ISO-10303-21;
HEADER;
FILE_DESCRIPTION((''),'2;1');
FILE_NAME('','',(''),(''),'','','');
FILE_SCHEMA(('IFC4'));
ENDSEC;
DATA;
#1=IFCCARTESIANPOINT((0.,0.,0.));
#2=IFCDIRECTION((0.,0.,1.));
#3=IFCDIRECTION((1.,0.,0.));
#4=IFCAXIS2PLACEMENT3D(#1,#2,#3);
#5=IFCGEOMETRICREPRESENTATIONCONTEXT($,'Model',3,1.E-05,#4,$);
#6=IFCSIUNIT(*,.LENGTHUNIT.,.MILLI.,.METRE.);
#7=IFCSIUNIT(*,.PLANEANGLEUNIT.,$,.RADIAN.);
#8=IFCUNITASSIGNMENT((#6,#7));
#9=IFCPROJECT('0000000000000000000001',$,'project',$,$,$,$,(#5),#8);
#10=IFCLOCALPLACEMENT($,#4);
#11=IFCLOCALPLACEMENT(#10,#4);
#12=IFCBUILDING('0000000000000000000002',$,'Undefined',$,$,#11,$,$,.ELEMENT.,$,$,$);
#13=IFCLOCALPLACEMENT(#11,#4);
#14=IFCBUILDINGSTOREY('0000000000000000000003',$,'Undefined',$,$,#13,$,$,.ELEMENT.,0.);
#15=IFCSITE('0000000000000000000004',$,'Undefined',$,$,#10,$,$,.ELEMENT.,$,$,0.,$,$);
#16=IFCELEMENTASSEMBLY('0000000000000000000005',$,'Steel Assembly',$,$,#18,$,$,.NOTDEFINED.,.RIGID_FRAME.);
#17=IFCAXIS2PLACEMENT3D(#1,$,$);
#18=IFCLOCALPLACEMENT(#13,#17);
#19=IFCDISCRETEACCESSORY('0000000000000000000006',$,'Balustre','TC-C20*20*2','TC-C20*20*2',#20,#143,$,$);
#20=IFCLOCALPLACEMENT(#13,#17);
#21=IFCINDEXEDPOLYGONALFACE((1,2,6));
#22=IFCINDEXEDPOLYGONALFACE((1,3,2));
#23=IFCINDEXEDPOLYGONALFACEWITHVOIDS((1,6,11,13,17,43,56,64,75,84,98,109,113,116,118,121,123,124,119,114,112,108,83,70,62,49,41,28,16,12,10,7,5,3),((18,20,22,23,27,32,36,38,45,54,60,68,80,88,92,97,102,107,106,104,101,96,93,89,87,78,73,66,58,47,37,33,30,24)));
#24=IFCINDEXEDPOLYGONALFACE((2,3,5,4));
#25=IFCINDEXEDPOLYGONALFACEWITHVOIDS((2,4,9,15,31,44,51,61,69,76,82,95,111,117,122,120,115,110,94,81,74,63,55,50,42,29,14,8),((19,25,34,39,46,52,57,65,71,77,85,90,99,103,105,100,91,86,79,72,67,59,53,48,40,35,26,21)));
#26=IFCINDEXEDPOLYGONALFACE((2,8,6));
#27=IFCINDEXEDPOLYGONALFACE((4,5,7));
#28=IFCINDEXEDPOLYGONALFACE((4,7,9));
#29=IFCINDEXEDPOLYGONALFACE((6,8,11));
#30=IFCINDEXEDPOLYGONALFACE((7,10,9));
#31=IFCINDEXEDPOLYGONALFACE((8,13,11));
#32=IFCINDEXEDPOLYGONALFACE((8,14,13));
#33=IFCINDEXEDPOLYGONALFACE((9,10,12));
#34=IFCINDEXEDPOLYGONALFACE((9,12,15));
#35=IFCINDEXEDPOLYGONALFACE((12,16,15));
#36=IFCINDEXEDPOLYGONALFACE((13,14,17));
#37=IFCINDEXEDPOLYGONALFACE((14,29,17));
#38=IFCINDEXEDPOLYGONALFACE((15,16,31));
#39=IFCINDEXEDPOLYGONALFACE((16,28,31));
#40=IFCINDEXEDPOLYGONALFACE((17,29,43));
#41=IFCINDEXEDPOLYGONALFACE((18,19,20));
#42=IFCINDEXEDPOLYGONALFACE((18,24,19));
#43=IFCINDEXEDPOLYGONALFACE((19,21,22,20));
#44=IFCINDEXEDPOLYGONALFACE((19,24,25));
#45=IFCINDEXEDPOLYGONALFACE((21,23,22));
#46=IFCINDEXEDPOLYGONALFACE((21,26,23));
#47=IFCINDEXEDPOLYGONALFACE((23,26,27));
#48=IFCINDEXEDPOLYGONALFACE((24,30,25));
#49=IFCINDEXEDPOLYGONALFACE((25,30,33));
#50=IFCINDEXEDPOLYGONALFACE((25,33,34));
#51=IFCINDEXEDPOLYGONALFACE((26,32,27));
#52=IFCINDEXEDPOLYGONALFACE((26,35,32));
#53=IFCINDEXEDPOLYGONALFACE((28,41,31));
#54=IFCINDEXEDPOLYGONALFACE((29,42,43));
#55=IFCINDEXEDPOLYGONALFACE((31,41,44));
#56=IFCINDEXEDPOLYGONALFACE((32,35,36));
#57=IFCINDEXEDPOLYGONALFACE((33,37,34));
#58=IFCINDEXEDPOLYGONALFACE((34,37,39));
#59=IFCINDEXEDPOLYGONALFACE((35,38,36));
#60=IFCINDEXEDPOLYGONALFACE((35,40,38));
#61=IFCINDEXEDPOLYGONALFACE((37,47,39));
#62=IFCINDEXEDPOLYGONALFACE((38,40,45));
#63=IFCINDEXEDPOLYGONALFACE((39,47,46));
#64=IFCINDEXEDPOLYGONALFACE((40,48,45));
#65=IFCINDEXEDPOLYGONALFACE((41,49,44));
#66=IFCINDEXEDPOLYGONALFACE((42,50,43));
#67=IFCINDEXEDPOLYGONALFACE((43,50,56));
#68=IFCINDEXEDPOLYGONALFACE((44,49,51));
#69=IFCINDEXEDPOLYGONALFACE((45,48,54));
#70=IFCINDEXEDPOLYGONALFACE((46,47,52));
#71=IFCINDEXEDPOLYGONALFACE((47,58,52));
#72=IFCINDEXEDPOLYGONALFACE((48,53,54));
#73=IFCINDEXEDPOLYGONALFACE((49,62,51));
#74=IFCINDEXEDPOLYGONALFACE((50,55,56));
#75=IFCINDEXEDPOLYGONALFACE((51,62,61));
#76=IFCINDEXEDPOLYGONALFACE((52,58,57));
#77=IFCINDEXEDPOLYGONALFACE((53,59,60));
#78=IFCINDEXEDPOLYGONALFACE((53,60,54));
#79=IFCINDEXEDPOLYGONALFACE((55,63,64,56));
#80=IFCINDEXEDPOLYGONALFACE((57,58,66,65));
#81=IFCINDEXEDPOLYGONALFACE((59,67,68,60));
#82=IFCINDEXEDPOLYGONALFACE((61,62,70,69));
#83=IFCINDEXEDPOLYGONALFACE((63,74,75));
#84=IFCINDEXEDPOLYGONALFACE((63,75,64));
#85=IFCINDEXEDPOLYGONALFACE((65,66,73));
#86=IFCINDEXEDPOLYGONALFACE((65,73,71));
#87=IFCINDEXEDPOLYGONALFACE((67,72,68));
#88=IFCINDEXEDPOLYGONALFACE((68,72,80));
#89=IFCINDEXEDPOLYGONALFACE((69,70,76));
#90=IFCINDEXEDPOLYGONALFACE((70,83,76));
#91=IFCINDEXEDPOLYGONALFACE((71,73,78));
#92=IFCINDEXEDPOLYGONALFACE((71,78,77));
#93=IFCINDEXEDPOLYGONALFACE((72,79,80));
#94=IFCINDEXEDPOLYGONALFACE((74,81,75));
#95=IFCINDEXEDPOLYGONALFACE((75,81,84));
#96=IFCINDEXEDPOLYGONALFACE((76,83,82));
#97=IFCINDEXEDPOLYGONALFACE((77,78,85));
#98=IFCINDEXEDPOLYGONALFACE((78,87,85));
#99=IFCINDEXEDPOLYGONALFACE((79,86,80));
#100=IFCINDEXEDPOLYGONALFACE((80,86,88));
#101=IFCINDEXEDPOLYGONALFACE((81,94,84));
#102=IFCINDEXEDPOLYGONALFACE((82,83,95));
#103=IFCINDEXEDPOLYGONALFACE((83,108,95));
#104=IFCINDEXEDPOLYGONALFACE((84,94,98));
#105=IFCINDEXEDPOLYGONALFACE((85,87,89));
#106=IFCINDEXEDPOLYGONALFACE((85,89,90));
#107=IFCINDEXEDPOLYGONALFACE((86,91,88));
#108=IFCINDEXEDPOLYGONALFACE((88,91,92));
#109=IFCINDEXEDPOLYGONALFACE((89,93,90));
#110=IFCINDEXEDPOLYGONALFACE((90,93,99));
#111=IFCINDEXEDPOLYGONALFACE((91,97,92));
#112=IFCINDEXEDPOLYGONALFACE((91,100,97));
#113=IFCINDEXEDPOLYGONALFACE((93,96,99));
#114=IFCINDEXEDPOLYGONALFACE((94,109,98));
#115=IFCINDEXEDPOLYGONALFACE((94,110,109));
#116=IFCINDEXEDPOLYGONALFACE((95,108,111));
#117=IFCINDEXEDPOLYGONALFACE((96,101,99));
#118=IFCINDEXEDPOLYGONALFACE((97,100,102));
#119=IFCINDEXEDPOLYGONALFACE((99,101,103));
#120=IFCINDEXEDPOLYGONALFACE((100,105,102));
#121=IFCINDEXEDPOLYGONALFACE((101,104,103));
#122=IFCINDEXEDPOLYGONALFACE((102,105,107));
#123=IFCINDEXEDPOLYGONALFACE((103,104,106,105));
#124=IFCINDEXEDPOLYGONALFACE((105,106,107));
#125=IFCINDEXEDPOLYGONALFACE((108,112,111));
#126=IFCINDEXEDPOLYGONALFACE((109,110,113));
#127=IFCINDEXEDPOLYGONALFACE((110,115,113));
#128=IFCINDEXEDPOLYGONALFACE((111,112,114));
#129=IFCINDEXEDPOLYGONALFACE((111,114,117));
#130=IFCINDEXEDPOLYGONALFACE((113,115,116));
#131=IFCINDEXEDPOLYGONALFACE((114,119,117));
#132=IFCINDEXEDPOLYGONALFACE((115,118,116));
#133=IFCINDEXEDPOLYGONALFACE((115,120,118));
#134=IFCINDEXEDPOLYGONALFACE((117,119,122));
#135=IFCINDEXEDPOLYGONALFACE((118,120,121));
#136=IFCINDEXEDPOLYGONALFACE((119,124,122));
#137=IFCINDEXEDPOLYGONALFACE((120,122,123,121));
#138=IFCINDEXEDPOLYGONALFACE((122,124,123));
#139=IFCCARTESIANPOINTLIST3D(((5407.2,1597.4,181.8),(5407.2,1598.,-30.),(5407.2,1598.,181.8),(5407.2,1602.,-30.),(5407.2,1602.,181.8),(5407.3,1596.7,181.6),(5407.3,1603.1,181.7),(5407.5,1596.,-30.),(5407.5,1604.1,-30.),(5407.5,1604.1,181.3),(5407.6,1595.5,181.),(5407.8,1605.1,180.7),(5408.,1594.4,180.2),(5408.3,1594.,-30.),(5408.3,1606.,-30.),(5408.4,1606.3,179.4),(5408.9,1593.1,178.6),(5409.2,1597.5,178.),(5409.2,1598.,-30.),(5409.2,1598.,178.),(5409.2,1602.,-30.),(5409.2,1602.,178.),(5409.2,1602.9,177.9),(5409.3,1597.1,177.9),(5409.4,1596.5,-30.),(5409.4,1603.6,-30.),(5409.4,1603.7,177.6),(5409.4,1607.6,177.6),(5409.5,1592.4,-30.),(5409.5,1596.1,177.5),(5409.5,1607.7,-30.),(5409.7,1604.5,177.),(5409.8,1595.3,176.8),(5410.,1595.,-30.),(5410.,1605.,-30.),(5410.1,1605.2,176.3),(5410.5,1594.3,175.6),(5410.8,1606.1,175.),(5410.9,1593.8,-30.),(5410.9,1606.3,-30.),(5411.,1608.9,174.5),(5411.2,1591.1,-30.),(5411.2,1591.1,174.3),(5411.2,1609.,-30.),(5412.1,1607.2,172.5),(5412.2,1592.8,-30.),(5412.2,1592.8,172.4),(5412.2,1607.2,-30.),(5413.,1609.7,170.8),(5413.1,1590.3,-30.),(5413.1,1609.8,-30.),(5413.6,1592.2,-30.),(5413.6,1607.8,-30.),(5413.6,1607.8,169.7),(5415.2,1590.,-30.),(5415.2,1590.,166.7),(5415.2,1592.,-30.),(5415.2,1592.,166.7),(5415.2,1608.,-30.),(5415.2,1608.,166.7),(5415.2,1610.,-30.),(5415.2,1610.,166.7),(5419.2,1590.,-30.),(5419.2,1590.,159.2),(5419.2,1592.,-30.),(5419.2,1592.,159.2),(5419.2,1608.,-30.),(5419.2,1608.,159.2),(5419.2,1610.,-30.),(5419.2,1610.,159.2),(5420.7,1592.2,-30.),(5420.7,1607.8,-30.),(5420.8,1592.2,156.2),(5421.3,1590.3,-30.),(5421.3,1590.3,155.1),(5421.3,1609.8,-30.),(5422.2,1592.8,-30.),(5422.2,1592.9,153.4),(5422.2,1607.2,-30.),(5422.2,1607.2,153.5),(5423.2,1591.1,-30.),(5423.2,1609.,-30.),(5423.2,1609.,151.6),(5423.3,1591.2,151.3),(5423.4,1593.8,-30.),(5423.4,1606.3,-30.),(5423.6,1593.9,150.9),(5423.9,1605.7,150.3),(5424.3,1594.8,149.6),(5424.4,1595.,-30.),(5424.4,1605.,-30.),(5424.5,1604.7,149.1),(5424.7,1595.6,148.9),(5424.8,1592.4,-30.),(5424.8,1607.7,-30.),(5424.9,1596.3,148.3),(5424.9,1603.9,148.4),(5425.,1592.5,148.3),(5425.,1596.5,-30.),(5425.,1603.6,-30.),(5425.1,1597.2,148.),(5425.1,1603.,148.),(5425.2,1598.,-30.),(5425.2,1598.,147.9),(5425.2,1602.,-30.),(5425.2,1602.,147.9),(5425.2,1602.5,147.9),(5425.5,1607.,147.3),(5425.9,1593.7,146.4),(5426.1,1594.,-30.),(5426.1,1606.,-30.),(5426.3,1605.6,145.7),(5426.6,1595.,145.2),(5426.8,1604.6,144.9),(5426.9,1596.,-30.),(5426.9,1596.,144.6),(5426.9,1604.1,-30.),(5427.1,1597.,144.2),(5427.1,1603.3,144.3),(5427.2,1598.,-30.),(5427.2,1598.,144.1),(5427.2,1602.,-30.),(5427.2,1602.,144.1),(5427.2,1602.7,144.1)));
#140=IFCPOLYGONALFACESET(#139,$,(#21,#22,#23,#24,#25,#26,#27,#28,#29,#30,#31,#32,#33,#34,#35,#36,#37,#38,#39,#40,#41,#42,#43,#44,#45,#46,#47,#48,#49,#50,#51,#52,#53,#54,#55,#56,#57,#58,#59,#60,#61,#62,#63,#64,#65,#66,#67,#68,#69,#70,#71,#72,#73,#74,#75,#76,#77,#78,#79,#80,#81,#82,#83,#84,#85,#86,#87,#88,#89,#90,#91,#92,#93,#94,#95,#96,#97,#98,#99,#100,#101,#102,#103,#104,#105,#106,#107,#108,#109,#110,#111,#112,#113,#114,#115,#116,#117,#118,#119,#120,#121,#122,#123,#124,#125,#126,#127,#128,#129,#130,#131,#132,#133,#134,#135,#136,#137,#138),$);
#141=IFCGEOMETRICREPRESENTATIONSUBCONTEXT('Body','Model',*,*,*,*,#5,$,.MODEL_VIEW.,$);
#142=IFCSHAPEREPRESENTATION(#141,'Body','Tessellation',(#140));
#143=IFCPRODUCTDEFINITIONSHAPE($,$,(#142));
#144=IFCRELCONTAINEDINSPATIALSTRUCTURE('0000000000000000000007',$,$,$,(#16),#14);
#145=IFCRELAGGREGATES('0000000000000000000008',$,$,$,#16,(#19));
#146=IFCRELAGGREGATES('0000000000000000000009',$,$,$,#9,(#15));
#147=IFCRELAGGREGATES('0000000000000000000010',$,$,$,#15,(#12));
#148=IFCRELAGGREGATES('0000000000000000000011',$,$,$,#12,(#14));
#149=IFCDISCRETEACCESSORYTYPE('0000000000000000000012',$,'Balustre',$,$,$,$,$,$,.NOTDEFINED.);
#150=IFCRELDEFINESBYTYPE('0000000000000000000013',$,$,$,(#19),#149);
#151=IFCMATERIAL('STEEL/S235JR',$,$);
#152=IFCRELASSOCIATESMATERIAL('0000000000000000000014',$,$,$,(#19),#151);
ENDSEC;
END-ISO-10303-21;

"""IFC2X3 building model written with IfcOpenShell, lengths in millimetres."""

from ifc_helpers import new_model, si_unit, frame, origin_with_axes, origin_2d_with_axis, place, context, subcontext, project, spatial, hollow_rectangle, extrude, clip, halfspace, material, type_object, element, aggregate, save


model = new_model("IFC2X3")

# Units and contexts
model_context = context("Model", 3, precision=1e-05, world=origin_with_axes())
body_context = subcontext(model_context, "Body", "Model", "MODEL_VIEW")
ifc_project = project(units=[si_unit("LENGTHUNIT", "METRE", prefix="MILLI"), si_unit("PLANEANGLEUNIT", "RADIAN")], contexts=[model_context])

# Site, building, storey
site_placement = place(None, origin_with_axes())
site = spatial("IfcSite", under=ifc_project, at=site_placement, Name="Undefined", CompositionType="ELEMENT", RefElevation=0.0)
building_placement = place(site_placement, origin_with_axes())
building = spatial("IfcBuilding", under=site, at=building_placement, Name="Undefined", CompositionType="ELEMENT")
storey_placement = place(building_placement, origin_with_axes())
storey = spatial("IfcBuildingStorey", under=building, at=storey_placement, Name="Undefined", CompositionType="ELEMENT", Elevation=0.0)

# Shared definitions
ifc_material = material(Name="STEEL/S235JR")

# Element assembly, discrete accessory
assembly_1_placement = place(storey_placement, origin_with_axes())
assembly_1 = element("IfcElementAssembly", 1, at=assembly_1_placement, inside=storey, Name="Steel Assembly", AssemblyPlace="NOTDEFINED", PredefinedType="RIGID_FRAME")
discrete_accessory_type_1 = type_object("IfcDiscreteAccessoryType", Name="Balustre")
discrete_accessory_1_placement = place(assembly_1_placement, frame((5417.2, 1600.0, -30.0), z_axis=(0.0, 0.0, 1.0), x_axis=(1.0, 0.0, 0.0)))
discrete_accessory_1 = element("IfcDiscreteAccessory", 2, at=discrete_accessory_1_placement, type_object=discrete_accessory_type_1, material=ifc_material, Name="Balustre", Description="TC-C20*20*2", ObjectType="TC-C20*20*2", context=body_context, shape_type="Clipping", body=[
    clip(extrude(hollow_rectangle(XDim=20.0, YDim=20.0, WallThickness=2.0, InnerFilletRadius=6.0, OuterFilletRadius=8.0, at=origin_2d_with_axis()), frame((0.0, 0.0, 212.0), z_axis=(0.0, 0.0, -1.0), x_axis=(-1.0, -0.000011, 0.0)), (0.0, 0.0, 1.0), 212.0), halfspace(frame((22.6, 0.0, 150.3), z_axis=(-0.883506, -0.000005, -0.46842), x_axis=(-0.000005, 1.0, 0.0)), True)),
])

aggregate(assembly_1, [discrete_accessory_1])

save(model, "model.ifc")
